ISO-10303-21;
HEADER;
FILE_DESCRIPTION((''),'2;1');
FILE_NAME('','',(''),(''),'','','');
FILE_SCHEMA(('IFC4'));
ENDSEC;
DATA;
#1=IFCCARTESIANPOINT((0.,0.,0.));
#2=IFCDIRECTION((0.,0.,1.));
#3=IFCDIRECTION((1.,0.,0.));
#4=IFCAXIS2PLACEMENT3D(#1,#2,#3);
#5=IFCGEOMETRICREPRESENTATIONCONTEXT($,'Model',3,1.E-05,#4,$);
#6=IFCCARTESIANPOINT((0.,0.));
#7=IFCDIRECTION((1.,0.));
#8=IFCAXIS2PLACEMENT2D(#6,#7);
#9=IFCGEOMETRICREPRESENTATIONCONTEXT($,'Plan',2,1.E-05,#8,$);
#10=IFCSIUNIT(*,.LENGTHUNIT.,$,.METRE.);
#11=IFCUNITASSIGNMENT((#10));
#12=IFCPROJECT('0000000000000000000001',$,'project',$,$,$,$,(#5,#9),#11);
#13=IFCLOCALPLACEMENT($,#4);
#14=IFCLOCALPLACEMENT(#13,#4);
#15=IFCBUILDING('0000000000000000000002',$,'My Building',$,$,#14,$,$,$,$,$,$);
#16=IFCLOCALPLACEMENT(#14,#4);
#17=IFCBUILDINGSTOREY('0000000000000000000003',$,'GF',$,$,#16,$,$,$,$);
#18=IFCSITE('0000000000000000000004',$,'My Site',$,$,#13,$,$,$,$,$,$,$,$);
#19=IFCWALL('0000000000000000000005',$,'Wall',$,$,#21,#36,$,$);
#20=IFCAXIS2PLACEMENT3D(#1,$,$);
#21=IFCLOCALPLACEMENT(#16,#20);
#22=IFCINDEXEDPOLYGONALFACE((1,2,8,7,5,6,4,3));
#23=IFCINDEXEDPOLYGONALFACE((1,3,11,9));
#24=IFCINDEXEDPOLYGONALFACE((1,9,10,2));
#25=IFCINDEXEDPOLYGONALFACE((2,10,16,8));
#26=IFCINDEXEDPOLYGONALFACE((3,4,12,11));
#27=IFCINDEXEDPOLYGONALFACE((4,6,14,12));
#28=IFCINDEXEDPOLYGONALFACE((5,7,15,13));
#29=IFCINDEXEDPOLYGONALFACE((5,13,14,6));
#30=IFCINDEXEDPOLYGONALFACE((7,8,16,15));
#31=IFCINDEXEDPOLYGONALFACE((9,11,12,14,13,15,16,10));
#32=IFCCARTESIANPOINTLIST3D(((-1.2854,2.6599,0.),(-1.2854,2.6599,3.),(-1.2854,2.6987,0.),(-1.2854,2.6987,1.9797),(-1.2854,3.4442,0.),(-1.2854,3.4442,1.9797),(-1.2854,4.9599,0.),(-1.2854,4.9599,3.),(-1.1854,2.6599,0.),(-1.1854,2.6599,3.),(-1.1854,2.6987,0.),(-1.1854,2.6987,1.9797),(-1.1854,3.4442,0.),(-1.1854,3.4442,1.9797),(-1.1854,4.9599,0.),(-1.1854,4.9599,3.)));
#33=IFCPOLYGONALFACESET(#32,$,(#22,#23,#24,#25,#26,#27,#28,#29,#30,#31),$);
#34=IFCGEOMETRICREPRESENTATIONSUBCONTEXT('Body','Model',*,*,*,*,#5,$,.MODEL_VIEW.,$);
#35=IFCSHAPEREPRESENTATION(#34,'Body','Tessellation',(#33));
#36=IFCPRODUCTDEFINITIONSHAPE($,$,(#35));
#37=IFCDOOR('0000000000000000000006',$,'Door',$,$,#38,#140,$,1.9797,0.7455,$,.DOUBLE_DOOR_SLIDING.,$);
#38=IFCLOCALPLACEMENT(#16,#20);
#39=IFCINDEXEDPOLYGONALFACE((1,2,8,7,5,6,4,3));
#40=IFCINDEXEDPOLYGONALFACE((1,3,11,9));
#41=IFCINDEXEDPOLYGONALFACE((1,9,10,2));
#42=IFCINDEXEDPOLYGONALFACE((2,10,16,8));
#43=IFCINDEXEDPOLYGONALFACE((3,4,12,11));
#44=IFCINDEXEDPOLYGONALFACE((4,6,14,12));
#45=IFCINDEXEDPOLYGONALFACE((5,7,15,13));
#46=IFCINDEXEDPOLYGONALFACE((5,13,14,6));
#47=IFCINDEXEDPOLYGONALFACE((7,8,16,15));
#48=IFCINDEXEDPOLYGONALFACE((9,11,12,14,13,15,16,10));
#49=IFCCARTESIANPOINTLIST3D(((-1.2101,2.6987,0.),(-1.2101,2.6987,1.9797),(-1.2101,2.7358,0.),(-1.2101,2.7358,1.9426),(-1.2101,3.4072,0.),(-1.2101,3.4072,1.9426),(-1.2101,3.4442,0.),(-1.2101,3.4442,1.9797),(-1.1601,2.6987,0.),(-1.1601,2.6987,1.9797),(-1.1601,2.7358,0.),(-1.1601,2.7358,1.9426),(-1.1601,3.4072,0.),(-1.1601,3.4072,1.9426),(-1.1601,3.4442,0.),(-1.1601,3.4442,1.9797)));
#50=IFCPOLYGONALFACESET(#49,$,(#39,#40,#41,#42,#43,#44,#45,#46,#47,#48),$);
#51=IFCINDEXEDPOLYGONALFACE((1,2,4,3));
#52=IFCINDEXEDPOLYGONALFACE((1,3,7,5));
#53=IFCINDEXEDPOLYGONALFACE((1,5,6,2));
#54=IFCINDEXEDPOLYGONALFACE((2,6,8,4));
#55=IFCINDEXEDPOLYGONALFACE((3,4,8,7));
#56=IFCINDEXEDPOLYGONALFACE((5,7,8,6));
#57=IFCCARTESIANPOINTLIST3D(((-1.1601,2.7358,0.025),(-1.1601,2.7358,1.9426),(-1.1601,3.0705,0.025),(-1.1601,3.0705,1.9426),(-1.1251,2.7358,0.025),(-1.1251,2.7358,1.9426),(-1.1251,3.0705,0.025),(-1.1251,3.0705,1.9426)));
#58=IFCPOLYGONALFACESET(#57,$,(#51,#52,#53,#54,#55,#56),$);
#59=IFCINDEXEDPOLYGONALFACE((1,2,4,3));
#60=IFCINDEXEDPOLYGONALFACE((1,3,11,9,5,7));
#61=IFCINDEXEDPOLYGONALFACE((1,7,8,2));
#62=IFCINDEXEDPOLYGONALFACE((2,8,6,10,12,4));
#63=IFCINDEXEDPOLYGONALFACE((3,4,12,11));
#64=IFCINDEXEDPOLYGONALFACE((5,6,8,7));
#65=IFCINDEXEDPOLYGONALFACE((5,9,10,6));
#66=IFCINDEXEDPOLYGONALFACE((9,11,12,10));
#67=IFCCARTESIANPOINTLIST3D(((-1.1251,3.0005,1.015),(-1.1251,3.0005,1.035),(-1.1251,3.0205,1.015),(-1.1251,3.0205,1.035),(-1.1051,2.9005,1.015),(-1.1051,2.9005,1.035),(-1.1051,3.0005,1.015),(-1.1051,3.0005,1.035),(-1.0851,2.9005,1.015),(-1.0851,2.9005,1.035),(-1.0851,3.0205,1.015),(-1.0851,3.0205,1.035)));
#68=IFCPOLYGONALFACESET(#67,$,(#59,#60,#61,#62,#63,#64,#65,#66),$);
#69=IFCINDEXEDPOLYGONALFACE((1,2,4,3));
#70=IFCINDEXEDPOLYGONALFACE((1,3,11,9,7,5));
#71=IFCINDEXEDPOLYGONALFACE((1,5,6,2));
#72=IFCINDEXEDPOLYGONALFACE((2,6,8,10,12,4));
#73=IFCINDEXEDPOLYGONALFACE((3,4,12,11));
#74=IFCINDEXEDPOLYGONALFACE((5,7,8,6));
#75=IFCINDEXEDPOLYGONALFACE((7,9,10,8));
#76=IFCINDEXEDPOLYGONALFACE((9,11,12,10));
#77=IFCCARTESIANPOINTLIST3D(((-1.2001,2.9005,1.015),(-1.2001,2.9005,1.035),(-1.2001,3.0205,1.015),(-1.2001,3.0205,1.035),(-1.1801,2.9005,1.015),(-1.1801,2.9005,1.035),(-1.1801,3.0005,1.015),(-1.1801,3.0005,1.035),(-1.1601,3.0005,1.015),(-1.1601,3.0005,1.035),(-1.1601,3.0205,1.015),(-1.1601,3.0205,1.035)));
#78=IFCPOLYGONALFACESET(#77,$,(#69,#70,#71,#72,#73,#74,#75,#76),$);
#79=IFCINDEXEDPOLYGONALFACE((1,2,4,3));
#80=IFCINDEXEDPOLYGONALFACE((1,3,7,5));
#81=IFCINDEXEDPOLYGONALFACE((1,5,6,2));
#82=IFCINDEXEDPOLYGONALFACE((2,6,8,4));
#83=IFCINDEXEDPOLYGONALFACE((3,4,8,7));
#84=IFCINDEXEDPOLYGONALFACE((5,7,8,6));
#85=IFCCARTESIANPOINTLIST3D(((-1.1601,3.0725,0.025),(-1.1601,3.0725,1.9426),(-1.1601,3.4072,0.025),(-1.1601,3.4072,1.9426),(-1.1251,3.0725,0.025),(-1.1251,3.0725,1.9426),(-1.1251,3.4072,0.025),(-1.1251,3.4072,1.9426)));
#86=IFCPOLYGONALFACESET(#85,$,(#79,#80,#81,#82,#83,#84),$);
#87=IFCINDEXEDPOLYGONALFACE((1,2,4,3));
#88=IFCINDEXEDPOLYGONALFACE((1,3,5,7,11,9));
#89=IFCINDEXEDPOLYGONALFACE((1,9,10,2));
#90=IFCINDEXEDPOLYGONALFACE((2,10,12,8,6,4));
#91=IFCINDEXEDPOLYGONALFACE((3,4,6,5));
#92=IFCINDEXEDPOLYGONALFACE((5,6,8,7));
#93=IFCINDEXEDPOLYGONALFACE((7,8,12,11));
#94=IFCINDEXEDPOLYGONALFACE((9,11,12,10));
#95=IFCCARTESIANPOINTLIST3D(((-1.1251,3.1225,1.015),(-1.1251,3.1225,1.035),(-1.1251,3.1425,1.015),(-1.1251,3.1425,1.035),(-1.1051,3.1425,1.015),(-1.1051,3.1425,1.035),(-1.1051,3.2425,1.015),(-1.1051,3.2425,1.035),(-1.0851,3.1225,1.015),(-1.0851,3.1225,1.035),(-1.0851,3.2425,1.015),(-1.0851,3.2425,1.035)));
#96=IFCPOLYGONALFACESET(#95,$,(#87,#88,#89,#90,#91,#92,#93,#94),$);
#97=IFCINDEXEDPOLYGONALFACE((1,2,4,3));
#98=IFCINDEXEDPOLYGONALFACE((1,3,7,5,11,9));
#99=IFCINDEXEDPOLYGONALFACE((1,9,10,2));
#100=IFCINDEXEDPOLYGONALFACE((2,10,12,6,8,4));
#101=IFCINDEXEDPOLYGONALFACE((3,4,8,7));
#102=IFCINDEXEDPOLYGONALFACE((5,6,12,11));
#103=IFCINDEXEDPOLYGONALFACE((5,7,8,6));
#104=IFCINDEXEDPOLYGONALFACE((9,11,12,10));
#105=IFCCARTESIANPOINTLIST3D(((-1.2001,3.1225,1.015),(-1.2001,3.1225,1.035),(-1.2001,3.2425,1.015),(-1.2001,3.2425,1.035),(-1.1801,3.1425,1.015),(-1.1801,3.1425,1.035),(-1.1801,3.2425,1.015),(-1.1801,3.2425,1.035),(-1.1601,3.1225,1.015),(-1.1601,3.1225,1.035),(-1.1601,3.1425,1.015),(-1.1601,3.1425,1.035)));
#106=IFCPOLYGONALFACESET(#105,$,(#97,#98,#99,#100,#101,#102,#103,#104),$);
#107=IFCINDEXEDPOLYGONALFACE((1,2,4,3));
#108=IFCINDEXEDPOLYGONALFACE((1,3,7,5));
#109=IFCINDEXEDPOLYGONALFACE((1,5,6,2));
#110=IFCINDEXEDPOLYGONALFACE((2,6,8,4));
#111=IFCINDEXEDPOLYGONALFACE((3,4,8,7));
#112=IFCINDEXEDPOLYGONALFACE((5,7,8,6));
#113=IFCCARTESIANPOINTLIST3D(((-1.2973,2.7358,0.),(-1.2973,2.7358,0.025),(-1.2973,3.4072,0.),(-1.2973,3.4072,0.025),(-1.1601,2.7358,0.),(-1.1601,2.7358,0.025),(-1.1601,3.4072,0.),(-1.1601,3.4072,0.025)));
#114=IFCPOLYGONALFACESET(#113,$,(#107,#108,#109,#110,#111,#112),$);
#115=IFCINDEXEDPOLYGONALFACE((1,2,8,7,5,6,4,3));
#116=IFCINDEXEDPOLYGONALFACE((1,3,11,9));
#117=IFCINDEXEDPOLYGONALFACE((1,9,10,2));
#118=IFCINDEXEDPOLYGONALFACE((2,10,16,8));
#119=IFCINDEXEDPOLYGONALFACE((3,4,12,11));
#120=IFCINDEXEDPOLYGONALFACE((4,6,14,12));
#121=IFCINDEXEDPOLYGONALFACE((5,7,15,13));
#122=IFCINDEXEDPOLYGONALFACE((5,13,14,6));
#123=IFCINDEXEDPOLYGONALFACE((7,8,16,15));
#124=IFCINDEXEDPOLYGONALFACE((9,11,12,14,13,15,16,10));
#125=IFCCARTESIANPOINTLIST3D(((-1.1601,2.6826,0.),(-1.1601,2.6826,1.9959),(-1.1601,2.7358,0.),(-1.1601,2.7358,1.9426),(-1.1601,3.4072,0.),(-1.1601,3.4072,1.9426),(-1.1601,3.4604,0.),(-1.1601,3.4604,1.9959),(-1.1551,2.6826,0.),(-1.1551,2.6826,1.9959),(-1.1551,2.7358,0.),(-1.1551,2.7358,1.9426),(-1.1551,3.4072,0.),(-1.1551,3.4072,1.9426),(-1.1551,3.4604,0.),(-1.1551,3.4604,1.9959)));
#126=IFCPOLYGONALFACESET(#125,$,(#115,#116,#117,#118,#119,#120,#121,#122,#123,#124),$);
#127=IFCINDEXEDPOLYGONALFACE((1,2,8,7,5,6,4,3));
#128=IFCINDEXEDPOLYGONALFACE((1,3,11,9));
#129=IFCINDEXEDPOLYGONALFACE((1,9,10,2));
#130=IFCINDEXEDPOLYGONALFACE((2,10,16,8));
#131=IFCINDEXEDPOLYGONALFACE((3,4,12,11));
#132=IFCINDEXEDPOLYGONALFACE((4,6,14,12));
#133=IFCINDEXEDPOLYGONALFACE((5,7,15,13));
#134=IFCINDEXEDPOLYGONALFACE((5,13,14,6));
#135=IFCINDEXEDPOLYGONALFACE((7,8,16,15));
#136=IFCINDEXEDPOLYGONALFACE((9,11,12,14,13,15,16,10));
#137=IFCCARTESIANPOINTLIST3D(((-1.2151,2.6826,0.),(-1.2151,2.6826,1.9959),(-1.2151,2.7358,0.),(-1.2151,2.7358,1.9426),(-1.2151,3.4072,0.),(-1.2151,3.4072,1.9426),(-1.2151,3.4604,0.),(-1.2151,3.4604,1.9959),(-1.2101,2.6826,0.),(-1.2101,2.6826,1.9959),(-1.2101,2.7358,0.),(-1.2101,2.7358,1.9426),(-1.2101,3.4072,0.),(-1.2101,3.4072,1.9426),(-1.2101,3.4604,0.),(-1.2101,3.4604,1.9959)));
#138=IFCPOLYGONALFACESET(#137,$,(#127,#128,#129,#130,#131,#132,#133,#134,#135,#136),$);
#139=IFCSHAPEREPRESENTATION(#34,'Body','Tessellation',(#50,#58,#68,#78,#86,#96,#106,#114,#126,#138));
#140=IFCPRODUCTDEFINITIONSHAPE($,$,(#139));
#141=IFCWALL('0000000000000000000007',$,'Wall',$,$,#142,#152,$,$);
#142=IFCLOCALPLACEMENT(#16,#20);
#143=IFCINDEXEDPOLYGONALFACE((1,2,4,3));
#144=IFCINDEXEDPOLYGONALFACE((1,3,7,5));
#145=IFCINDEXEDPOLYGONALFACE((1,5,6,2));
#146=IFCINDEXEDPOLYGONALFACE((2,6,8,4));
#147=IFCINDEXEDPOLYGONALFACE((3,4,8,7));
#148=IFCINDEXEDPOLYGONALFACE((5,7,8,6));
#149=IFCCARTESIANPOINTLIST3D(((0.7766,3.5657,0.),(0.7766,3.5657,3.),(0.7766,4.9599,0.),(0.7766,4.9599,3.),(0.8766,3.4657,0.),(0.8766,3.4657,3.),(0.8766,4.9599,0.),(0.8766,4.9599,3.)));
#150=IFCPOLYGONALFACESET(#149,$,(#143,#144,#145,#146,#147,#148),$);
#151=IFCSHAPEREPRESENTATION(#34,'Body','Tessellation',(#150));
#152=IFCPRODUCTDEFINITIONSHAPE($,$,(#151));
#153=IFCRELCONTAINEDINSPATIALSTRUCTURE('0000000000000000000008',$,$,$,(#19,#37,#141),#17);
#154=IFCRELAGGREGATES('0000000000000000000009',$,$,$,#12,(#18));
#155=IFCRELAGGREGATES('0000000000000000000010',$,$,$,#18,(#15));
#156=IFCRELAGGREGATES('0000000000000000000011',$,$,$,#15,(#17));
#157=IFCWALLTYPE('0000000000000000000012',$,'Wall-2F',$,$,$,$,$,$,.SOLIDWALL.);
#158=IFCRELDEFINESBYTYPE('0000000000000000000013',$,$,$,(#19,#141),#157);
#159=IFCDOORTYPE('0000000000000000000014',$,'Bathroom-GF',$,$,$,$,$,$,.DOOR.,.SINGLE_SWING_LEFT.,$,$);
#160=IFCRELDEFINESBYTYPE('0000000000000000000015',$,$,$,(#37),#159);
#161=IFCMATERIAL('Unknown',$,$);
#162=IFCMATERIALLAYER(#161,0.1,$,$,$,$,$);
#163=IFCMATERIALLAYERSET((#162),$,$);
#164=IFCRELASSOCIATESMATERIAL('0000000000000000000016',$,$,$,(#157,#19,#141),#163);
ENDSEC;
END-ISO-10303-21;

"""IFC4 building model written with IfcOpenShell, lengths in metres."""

from ifc_helpers import new_model, entity, si_unit, frame, origin_with_axes, origin_2d_with_axis, place, context, subcontext, project, spatial, line, indexed_curve, outline, extrude, shape, source, transform, mapped, material, layer, layer_set, layer_usage, type_object, type_shapes, element, fill, save


model = new_model("IFC4")

# Units and contexts
model_context = context("Model", 3, precision=1e-05, world=origin_with_axes())
plan_context = context("Plan", 2, precision=1e-05, world=origin_2d_with_axis())
body_context_1 = subcontext(model_context, "Body", "Model", "MODEL_VIEW")
body_context_2 = subcontext(plan_context, "Body", "Plan", "PLAN_VIEW")
ifc_project = project(units=[si_unit("LENGTHUNIT", "METRE")], contexts=[model_context, plan_context])

# Site, building, storey
site_placement = place(None, origin_with_axes())
site = spatial("IfcSite", under=ifc_project, at=site_placement, Name="My Site")
building_placement = place(site_placement, origin_with_axes())
building = spatial("IfcBuilding", under=site, at=building_placement, Name="My Building")
storey_placement = place(building_placement, origin_with_axes())
storey = spatial("IfcBuildingStorey", under=building, at=storey_placement, Name="GF")

# Shared definitions
ifc_material = material(Name="Unknown")

# Shared definitions
ifc_layer_1 = layer(ifc_material, 0.1)
ifc_layer_set_1 = layer_set([ifc_layer_1])
wall_type = type_object("IfcWallType", Name="Wall-2F", PredefinedType="SOLIDWALL", material=ifc_layer_set_1)

# Wall, opening, door
ifc_layer_usage_1 = layer_usage(ifc_layer_set_1, "AXIS2", "POSITIVE", 0.0)
wall_1_placement = place(storey_placement, frame((-1.1854, 2.6599, 0.0), z_axis=(0.0, 0.0, 1.0), x_axis=(0.0, 1.0, 0.0)))
wall_1 = element("IfcWall", 1, at=wall_1_placement, inside=storey, type_object=wall_type, material=ifc_layer_usage_1, Name="Wall", context=body_context_1, shape_type="SweptSolid", body=[
    extrude(outline(indexed_curve([(0.0, 0.0), (0.0, 0.1), (2.3, 0.1), (2.3, 0.0)], segments=[line(1, 2, 3, 4, 1)])), origin_with_axes(), (0.0, 0.0, 1.0), 3.0),
])
shared_shape_1 = source(origin_with_axes(), body_context_1, "Body", "SweptSolid", [
    extrude(outline(indexed_curve([(0.0, 0.0), (0.7455, 0.0), (0.7455, 1.9797), (0.0, 1.9797)], segments=[line(1, 2, 3, 4, 1)])), frame((0.0, -0.6, 0.0), z_axis=(0.0, -1.0, 0.0), x_axis=(1.0, 0.0, 0.0)), (0.0, 0.0, -1.0), 1.2),
])
opening_1_placement = place(wall_1_placement, frame((0.0388, -0.0253, 0.0), z_axis=(0.0, 0.0, 1.0), x_axis=(1.0, 0.0, 0.0)))
opening_1 = element("IfcOpeningElement", 2, at=opening_1_placement, cuts=wall_1, PredefinedType="OPENING", context=body_context_1, shape_type="MappedRepresentation", body=[
    mapped(shared_shape_1, transform((0.0, 0.0, 0.0), x_axis=(1.0, 0.0, 0.0), y_axis=(0.0, 1.0, 0.0), z_axis=(0.0, 0.0, 1.0), scale=1.0)),
])
door_type_1 = type_object("IfcDoorType", Name="Bathroom-GF", OperationType="SINGLE_SWING_LEFT", PredefinedType="DOOR")
shared_shape_2 = source(origin_with_axes(), body_context_1, "Body", "SweptSolid", [
    extrude(outline(indexed_curve([(0.0, 0.0), (0.0, 1.9797), (0.7455, 1.9797), (0.7455, 0.0), (0.7084, 0.0), (0.7084, 1.9426), (0.0371, 1.9426), (0.0371, 0.0)], segments=[line(1, 2, 3, 4, 5, 6, 7, 8, 1)])), frame((0.0, 0.0, 0.0), z_axis=(0.0, -1.0, 0.0), x_axis=(1.0, 0.0, 0.0)), (0.0, 0.0, -1.0), 0.05),
    extrude(outline(indexed_curve([(0.0, 0.0), (0.3347, 0.0), (0.3347, 0.035), (0.0, 0.035)], segments=[line(1, 2, 3, 4, 1)])), frame((0.0371, -0.035, 0.025), z_axis=(0.0, 0.0, 1.0), x_axis=(1.0, 0.0, 0.0)), (0.0, 0.0, 1.0), 1.9176),
    extrude(outline(indexed_curve([(0.0, 0.0), (0.0, -0.04), (-0.12, -0.04), (-0.12, -0.02), (-0.02, -0.02), (-0.02, 0.0)], segments=[line(1, 2, 3, 4, 5, 6, 1)])), frame((0.3218, -0.035, 1.015), z_axis=(0.0, 0.0, 1.0), x_axis=(1.0, 0.0, 0.0)), (0.0, 0.0, 1.0), 0.02),
    extrude(outline(indexed_curve([(0.0, 0.0), (0.0, 0.04), (-0.12, 0.04), (-0.12, 0.02), (-0.02, 0.02), (-0.02, 0.0)], segments=[line(1, 2, 3, 4, 5, 6, 1)])), frame((0.3218, 0.0, 1.015), z_axis=(0.0, 0.0, 1.0), x_axis=(1.0, 0.0, 0.0)), (0.0, 0.0, 1.0), 0.02),
    extrude(outline(indexed_curve([(0.0, 0.0), (-0.3347, 0.0), (-0.3347, 0.035), (0.0, 0.035)], segments=[line(1, 2, 3, 4, 1)])), frame((0.7084, -0.035, 0.025), z_axis=(0.0, 0.0, 1.0), x_axis=(1.0, 0.0, 0.0)), (0.0, 0.0, 1.0), 1.9176),
    extrude(outline(indexed_curve([(0.0, 0.0), (0.0, -0.04), (0.12, -0.04), (0.12, -0.02), (0.02, -0.02), (0.02, 0.0)], segments=[line(1, 2, 3, 4, 5, 6, 1)])), frame((0.4238, -0.035, 1.015), z_axis=(0.0, 0.0, 1.0), x_axis=(1.0, 0.0, 0.0)), (0.0, 0.0, 1.0), 0.02),
    extrude(outline(indexed_curve([(0.0, 0.0), (0.0, 0.04), (0.12, 0.04), (0.12, 0.02), (0.02, 0.02), (0.02, 0.0)], segments=[line(1, 2, 3, 4, 5, 6, 1)])), frame((0.4238, 0.0, 1.015), z_axis=(0.0, 0.0, 1.0), x_axis=(1.0, 0.0, 0.0)), (0.0, 0.0, 1.0), 0.02),
    extrude(outline(indexed_curve([(0.0, 0.0), (0.6713, 0.0), (0.6713, 0.1372), (0.0, 0.1372)], segments=[line(1, 2, 3, 4, 1)])), frame((0.0371, 0.0, 0.0), z_axis=(0.0, 0.0, 1.0), x_axis=(1.0, 0.0, 0.0)), (0.0, 0.0, 1.0), 0.025),
    extrude(outline(indexed_curve([(0.0, 0.0), (0.0, 1.9959), (0.7778, 1.9959), (0.7778, 0.0), (0.7246, 0.0), (0.7246, 1.9426), (0.0532, 1.9426), (0.0532, 0.0)], segments=[line(1, 2, 3, 4, 5, 6, 7, 8, 1)])), frame((-0.0162, -0.005, 0.0), z_axis=(0.0, -1.0, 0.0), x_axis=(1.0, 0.0, 0.0)), (0.0, 0.0, -1.0), 0.005),
    extrude(outline(indexed_curve([(0.0, 0.0), (0.0, 1.9959), (0.7778, 1.9959), (0.7778, 0.0), (0.7246, 0.0), (0.7246, 1.9426), (0.0532, 1.9426), (0.0532, 0.0)], segments=[line(1, 2, 3, 4, 5, 6, 7, 8, 1)])), frame((-0.0162, 0.05, 0.0), z_axis=(0.0, -1.0, 0.0), x_axis=(1.0, 0.0, 0.0)), (0.0, 0.0, -1.0), 0.005),
])
shared_shape_3 = source(origin_with_axes(), body_context_2, "Body", "Curve2D", [
    entity("IfcIndexedPolyCurve", entity("IfcCartesianPointList2D", [[0.0, 0.0], [0.0371, 0.0], [0.0371, 0.05], [0.0, 0.05]]), [entity("IfcLineIndex", [1, 2, 3, 4, 1])]),
    entity("IfcIndexedPolyCurve", entity("IfcCartesianPointList2D", [[0.7455, 0.0], [0.7084, 0.0], [0.7084, 0.05], [0.7455, 0.05]]), [entity("IfcLineIndex", [1, 2, 3, 4, 1])]),
    entity("IfcIndexedPolyCurve", entity("IfcCartesianPointList2D", [[-0.1307, -0.035], [0.2049, -0.035], [0.2049, 0.0], [-0.1307, 0.0]]), [entity("IfcLineIndex", [1, 2, 3, 4, 1])]),
    entity("IfcIndexedPolyCurve", entity("IfcCartesianPointList2D", [[0.8763, -0.035], [0.5406, -0.035], [0.5406, 0.0], [0.8763, 0.0]]), [entity("IfcLineIndex", [1, 2, 3, 4, 1])]),
])
type_shapes(door_type_1, [shared_shape_2, shared_shape_3])
door_1_placement = place(opening_1_placement, frame((0.0, 0.0, 0.0), z_axis=(0.0, 0.0, 1.0), x_axis=(1.0, 0.0, 0.0)))
door_1 = element("IfcDoor", 3, at=door_1_placement, inside=storey, type_object=door_type_1, Name="Door", OperationType="DOUBLE_DOOR_SLIDING", OverallHeight=1.9797, OverallWidth=0.7455, shapes=[
    shape(body_context_1, "Body", "MappedRepresentation", [mapped(shared_shape_2, transform((0.0, 0.0, 0.0), x_axis=(1.0, 0.0, 0.0), y_axis=(0.0, 1.0, 0.0), z_axis=(0.0, 0.0, 1.0), scale=1.0))]),
    shape(body_context_2, "Body", "MappedRepresentation", [mapped(shared_shape_3, transform((0.0, 0.0, 0.0), x_axis=(1.0, 0.0, 0.0), y_axis=(0.0, 1.0, 0.0), z_axis=(0.0, 0.0, 1.0), scale=1.0))]),
])
fill(opening_1, door_1)

# Wall
ifc_layer_usage_2 = layer_usage(ifc_layer_set_1, "AXIS2", "POSITIVE", 0.0)
wall_2_placement = place(storey_placement, frame((0.7766, 5.0599, 0.0), z_axis=(0.0, 0.0, 1.0), x_axis=(0.0, -1.0, 0.0)))
element("IfcWall", 4, at=wall_2_placement, inside=storey, type_object=wall_type, material=ifc_layer_usage_2, Name="Wall", context=body_context_1, shape_type="SweptSolid", body=[
    extrude(outline(indexed_curve([(0.1, 0.0), (0.1, 0.1), (1.5942, 0.1), (1.4942, 0.0)], segments=[line(1, 2, 3, 4, 1)])), origin_with_axes(), (0.0, 0.0, 1.0), 3.0),
])

save(model, "model.ifc")
